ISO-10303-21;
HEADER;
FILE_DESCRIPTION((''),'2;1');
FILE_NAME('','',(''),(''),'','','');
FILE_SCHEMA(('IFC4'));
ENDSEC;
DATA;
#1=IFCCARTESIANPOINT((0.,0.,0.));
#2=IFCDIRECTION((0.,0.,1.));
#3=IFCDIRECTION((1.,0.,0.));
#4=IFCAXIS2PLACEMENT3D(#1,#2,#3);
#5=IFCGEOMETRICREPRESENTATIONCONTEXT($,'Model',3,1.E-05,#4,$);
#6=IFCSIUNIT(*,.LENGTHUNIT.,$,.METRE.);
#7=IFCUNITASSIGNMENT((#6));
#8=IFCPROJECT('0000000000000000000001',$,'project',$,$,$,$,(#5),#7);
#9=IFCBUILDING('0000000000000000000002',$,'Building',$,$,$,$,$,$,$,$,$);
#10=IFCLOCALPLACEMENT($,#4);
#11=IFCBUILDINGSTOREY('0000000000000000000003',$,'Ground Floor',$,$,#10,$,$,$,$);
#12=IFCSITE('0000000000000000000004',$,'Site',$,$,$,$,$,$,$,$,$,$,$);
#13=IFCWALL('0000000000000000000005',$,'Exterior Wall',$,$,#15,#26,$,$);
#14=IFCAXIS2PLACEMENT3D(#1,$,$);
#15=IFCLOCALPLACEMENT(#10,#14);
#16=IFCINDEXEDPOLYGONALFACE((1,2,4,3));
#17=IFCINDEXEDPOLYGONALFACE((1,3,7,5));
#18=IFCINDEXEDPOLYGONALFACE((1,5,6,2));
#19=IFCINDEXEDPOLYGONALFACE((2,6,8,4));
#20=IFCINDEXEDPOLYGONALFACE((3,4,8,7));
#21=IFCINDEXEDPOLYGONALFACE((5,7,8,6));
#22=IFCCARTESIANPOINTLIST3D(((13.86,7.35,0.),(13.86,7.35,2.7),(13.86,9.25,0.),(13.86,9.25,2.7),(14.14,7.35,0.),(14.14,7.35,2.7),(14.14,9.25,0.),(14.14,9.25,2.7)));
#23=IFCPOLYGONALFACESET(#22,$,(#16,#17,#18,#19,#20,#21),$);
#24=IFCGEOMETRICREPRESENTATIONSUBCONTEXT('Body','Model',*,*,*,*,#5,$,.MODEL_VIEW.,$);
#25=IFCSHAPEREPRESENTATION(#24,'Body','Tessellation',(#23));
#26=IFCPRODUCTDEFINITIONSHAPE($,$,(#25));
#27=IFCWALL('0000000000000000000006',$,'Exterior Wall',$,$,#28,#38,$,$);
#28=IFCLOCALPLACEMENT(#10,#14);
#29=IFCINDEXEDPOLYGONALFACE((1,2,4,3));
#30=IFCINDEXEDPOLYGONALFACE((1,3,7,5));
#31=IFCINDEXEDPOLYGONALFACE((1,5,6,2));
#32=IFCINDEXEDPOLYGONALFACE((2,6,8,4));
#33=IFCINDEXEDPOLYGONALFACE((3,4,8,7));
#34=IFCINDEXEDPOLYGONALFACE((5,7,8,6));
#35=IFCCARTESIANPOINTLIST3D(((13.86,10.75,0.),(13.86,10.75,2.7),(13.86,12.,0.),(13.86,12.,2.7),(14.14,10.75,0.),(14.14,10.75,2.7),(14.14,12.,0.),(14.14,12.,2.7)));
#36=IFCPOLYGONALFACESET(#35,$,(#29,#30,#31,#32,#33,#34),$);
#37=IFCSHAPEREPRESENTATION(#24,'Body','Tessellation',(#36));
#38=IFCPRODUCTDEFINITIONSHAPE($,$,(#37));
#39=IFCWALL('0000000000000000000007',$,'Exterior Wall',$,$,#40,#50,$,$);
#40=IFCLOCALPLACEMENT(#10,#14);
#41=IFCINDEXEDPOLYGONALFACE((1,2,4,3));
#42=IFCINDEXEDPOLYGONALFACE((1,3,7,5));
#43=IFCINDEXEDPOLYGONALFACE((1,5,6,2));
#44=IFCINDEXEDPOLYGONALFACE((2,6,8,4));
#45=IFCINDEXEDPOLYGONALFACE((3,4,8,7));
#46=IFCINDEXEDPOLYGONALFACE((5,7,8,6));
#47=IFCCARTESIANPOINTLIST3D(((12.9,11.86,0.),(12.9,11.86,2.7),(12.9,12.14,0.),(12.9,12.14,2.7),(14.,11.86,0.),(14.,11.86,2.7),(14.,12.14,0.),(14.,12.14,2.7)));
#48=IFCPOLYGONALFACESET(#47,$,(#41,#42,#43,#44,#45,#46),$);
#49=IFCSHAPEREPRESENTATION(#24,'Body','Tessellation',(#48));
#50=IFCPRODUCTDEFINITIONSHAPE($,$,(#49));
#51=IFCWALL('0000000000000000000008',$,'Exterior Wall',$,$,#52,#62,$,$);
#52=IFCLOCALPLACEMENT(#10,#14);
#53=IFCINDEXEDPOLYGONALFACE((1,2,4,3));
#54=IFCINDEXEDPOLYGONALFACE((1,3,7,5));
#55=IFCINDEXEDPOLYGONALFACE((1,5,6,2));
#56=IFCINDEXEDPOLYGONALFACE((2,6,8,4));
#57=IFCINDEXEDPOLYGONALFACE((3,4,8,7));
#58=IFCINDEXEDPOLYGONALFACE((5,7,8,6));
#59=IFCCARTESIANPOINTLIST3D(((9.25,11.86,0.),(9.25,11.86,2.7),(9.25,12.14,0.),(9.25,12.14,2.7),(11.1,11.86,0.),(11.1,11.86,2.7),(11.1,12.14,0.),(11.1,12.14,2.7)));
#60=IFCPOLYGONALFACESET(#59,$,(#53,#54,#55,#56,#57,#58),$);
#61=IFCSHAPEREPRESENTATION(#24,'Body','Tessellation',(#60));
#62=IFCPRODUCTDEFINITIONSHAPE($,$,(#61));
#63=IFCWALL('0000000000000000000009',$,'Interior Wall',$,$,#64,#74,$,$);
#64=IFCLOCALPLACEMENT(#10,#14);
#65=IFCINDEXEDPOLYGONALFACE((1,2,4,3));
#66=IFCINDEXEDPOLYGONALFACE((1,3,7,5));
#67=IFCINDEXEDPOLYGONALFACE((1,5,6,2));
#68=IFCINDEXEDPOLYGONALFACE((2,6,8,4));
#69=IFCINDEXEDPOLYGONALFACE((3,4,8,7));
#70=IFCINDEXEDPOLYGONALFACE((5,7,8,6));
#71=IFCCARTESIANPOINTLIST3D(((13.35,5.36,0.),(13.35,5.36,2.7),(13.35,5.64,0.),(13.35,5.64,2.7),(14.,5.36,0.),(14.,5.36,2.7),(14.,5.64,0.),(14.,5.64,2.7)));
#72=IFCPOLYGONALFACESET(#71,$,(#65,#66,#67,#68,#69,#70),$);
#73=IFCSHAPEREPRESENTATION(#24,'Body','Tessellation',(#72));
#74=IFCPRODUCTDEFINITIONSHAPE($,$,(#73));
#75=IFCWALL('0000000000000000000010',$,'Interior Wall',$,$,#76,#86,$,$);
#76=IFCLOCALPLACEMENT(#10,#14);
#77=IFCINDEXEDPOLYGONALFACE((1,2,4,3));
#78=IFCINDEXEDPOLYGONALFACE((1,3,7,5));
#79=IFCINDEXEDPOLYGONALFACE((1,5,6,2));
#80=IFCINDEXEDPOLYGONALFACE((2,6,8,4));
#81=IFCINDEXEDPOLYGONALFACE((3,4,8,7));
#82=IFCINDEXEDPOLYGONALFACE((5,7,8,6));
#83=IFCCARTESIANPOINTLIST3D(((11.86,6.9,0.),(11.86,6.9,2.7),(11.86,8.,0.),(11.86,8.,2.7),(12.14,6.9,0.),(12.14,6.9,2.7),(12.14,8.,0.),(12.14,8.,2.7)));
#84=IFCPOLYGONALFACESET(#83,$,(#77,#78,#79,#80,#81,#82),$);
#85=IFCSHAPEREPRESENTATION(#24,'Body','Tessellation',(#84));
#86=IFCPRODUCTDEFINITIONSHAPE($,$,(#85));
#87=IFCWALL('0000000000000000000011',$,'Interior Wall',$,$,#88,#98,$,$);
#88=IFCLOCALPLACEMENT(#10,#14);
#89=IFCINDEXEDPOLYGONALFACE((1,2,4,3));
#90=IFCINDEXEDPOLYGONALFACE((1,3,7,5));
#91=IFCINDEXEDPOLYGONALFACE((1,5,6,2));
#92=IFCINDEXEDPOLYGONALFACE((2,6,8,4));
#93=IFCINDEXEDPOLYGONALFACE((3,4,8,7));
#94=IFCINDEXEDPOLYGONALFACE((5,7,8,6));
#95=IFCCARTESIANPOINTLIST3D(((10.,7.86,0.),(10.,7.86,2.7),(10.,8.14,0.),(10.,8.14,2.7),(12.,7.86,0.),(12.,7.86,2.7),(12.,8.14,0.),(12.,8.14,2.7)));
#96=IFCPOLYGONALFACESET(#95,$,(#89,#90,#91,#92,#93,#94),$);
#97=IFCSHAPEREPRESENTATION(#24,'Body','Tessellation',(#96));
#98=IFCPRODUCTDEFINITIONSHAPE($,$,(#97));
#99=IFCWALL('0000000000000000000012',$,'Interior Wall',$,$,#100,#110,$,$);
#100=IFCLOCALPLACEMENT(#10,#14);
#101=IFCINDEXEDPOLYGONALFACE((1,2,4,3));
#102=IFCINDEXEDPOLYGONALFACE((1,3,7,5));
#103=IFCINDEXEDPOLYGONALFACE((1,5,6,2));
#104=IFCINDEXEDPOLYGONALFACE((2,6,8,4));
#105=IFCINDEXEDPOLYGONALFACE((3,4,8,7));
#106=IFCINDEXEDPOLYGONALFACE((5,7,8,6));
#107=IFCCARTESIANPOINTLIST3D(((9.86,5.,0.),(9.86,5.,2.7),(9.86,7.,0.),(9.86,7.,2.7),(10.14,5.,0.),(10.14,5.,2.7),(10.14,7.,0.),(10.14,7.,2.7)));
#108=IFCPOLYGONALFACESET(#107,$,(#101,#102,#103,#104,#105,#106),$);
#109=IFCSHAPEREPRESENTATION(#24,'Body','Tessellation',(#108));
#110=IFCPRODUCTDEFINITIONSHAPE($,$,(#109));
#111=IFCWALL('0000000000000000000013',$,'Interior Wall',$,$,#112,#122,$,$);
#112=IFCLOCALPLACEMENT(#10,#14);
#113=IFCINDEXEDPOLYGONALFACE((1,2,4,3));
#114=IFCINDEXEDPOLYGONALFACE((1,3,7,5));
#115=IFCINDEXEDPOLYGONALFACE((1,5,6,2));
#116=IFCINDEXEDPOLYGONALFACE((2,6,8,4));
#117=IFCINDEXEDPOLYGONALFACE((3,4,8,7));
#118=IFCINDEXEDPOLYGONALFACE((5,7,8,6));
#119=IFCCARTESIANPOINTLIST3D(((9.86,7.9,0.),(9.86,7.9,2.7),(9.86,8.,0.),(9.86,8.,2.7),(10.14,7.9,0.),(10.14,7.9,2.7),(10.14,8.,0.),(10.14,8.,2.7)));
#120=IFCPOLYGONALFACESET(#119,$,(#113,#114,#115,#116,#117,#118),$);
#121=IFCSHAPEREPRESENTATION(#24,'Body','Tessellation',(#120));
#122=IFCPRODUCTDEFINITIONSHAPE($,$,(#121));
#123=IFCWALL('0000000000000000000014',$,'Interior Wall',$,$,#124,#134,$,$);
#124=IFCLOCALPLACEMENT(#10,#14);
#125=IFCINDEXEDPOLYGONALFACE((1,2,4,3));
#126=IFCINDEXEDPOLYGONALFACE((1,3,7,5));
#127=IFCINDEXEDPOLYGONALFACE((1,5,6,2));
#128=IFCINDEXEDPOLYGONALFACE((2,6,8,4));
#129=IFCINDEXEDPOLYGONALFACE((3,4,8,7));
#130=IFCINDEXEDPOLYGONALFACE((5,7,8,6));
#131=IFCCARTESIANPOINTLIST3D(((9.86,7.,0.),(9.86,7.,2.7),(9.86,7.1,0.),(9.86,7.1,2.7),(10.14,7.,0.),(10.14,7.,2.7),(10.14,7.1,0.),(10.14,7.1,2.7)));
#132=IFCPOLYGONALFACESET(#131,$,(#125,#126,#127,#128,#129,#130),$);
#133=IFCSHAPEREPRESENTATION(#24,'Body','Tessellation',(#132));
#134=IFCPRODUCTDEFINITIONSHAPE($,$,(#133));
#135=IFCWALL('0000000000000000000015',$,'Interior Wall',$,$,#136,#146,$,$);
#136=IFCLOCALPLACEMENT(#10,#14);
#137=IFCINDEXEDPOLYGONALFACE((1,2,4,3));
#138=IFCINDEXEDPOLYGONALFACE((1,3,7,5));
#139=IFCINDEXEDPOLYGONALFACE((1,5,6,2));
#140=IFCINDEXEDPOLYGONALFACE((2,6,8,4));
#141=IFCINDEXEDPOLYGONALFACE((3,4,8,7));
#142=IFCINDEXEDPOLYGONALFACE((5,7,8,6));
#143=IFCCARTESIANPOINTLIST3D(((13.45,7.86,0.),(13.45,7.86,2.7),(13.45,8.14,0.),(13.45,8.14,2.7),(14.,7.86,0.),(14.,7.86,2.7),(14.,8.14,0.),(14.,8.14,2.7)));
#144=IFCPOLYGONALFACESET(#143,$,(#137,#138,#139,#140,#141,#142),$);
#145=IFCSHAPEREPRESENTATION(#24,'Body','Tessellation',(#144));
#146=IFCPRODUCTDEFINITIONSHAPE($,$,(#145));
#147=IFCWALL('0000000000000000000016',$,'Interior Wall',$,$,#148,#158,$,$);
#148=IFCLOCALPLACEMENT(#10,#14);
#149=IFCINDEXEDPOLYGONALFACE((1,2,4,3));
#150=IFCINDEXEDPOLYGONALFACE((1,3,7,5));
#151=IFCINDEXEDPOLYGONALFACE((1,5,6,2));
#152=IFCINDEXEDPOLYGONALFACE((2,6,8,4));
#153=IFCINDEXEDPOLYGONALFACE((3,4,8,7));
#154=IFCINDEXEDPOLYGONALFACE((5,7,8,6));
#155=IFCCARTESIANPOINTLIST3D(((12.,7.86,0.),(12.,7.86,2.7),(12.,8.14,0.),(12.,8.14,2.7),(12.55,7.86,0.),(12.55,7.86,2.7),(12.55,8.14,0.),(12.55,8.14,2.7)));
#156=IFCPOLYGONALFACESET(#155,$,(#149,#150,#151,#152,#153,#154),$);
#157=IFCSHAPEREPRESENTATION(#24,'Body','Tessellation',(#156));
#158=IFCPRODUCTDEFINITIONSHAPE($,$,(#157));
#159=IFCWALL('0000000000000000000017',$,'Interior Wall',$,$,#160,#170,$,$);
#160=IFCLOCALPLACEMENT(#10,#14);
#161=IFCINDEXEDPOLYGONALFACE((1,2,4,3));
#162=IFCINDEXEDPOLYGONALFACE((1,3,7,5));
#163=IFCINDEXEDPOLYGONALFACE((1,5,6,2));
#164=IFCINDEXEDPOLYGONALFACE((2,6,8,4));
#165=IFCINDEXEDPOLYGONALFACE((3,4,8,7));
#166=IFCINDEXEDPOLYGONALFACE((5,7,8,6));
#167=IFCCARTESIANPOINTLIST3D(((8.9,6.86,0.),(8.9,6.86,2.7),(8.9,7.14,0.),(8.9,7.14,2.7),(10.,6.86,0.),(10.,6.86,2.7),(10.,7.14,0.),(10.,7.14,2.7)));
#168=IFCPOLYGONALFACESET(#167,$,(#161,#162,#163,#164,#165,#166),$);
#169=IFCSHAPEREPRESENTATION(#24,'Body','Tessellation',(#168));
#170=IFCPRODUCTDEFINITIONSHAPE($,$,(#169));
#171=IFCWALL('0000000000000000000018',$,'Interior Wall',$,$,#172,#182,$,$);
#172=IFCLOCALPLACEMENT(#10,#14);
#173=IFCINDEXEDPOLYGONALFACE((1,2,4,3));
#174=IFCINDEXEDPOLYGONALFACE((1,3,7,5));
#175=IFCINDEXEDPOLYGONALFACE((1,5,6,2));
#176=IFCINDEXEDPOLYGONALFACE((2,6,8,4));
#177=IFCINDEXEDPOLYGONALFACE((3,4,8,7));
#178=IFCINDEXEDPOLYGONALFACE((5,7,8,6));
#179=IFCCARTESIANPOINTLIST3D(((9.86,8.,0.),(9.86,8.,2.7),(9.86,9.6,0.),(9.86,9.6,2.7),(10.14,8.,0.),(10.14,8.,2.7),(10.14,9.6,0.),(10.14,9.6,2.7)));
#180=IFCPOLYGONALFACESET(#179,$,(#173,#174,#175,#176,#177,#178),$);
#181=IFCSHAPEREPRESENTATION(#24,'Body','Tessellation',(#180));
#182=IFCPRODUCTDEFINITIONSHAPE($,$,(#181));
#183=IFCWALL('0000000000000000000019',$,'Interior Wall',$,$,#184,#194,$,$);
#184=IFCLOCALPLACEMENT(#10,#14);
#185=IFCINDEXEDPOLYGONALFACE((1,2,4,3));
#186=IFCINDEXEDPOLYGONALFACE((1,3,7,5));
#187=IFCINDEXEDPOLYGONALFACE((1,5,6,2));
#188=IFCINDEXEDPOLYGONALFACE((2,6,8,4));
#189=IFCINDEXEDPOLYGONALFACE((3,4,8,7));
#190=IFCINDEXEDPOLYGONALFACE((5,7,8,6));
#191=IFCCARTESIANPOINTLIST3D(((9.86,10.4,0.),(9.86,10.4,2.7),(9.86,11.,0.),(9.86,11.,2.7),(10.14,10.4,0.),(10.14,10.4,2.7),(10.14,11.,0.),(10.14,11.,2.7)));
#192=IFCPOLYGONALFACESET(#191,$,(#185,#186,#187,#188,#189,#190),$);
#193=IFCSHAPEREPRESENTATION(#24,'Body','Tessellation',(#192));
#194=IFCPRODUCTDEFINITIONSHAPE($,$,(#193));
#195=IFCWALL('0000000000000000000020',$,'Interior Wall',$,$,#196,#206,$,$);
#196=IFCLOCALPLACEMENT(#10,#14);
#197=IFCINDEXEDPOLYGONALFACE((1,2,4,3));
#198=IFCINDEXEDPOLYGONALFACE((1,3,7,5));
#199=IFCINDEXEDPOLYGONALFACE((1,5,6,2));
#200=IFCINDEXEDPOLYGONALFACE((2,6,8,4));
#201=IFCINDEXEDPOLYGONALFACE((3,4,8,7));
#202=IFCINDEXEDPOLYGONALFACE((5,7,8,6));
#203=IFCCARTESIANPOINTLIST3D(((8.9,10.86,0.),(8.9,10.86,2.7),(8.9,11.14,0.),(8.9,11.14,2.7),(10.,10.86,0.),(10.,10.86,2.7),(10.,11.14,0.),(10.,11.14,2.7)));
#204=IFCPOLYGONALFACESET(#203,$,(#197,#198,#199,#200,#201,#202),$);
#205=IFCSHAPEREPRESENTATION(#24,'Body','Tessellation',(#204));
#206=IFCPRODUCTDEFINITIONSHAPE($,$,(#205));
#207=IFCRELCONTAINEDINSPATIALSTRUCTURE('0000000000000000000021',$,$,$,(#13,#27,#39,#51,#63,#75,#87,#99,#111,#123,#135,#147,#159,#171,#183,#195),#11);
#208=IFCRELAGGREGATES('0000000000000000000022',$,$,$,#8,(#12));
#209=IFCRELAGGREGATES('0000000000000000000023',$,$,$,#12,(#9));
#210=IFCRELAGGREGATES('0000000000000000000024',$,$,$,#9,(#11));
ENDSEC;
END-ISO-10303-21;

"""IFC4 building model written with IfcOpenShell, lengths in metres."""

from ifc_helpers import new_model, si_unit, frame, origin_with_axes, place, context, subcontext, project, spatial, indexed_curve, outline, extrude, element, save


model = new_model("IFC4")

# Units and contexts
model_context = context("Model", 3, precision=1e-05, world=origin_with_axes())
body_context = subcontext(model_context, "Body", "Model", "MODEL_VIEW")
ifc_project = project(units=[si_unit("LENGTHUNIT", "METRE")], contexts=[model_context])

# Site, building, storey
site = spatial("IfcSite", under=ifc_project, Name="Site")
building = spatial("IfcBuilding", under=site, Name="Building")
storey_placement = place(None, origin_with_axes())
storey = spatial("IfcBuildingStorey", under=building, at=storey_placement, Name="Ground Floor")

# Walls
wall_1_placement = place(storey_placement, frame((14.0, 7.35, 0.0), z_axis=(0.0, 0.0, 1.0), x_axis=(0.0, 1.0, 0.0)))
element("IfcWall", 1, at=wall_1_placement, inside=storey, Name="Exterior Wall", context=body_context, shape_type="SweptSolid", body=[
    extrude(outline(indexed_curve([(0.0, 0.0), (0.0, 0.28), (1.9, 0.28), (1.9, 0.0), (0.0, 0.0)], self_intersect=False)), frame((0.0, -0.14, 0.0), z_axis=(0.0, 0.0, 1.0), x_axis=(1.0, 0.0, 0.0)), (0.0, 0.0, 1.0), 2.7),
])
wall_2_placement = place(storey_placement, frame((14.0, 10.75, 0.0), z_axis=(0.0, 0.0, 1.0), x_axis=(0.0, 1.0, 0.0)))
element("IfcWall", 2, at=wall_2_placement, inside=storey, Name="Exterior Wall", context=body_context, shape_type="SweptSolid", body=[
    extrude(outline(indexed_curve([(0.0, 0.0), (0.0, 0.28), (1.25, 0.28), (1.25, 0.0), (0.0, 0.0)], self_intersect=False)), frame((0.0, -0.14, 0.0), z_axis=(0.0, 0.0, 1.0), x_axis=(1.0, 0.0, 0.0)), (0.0, 0.0, 1.0), 2.7),
])
wall_3_placement = place(storey_placement, frame((14.0, 12.0, 0.0), z_axis=(0.0, 0.0, 1.0), x_axis=(-1.0, 0.0, 0.0)))
element("IfcWall", 3, at=wall_3_placement, inside=storey, Name="Exterior Wall", context=body_context, shape_type="SweptSolid", body=[
    extrude(outline(indexed_curve([(0.0, 0.0), (0.0, 0.28), (1.1, 0.28), (1.1, 0.0), (0.0, 0.0)], self_intersect=False)), frame((0.0, -0.14, 0.0), z_axis=(0.0, 0.0, 1.0), x_axis=(1.0, 0.0, 0.0)), (0.0, 0.0, 1.0), 2.7),
])
wall_4_placement = place(storey_placement, frame((11.1, 12.0, 0.0), z_axis=(0.0, 0.0, 1.0), x_axis=(-1.0, 0.0, 0.0)))
element("IfcWall", 4, at=wall_4_placement, inside=storey, Name="Exterior Wall", context=body_context, shape_type="SweptSolid", body=[
    extrude(outline(indexed_curve([(0.0, 0.0), (0.0, 0.28), (1.85, 0.28), (1.85, 0.0), (0.0, 0.0)], self_intersect=False)), frame((0.0, -0.14, 0.0), z_axis=(0.0, 0.0, 1.0), x_axis=(1.0, 0.0, 0.0)), (0.0, 0.0, 1.0), 2.7),
])
wall_5_placement = place(storey_placement, frame((14.0, 5.5, 0.0), z_axis=(0.0, 0.0, 1.0), x_axis=(-1.0, 0.0, 0.0)))
element("IfcWall", 5, at=wall_5_placement, inside=storey, Name="Interior Wall", context=body_context, shape_type="SweptSolid", body=[
    extrude(outline(indexed_curve([(0.0, 0.0), (0.0, 0.28), (0.65, 0.28), (0.65, 0.0), (0.0, 0.0)], self_intersect=False)), frame((0.0, -0.14, 0.0), z_axis=(0.0, 0.0, 1.0), x_axis=(1.0, 0.0, 0.0)), (0.0, 0.0, 1.0), 2.7),
])
wall_6_placement = place(storey_placement, frame((12.0, 6.9, 0.0), z_axis=(0.0, 0.0, 1.0), x_axis=(0.0, 1.0, 0.0)))
element("IfcWall", 6, at=wall_6_placement, inside=storey, Name="Interior Wall", context=body_context, shape_type="SweptSolid", body=[
    extrude(outline(indexed_curve([(0.0, 0.0), (0.0, 0.28), (1.1, 0.28), (1.1, 0.0), (0.0, 0.0)], self_intersect=False)), frame((0.0, -0.14, 0.0), z_axis=(0.0, 0.0, 1.0), x_axis=(1.0, 0.0, 0.0)), (0.0, 0.0, 1.0), 2.7),
])
for number, where, z_axis, x_axis, name in (
    (7, (12.0, 8.0, 0.0), (0.0, 0.0, 1.0), (-1.0, 0.0, 0.0), "Interior Wall"),
    (8, (10.0, 7.0, 0.0), (0.0, 0.0, 1.0), (0.0, -1.0, 0.0), "Interior Wall"),
):
    element("IfcWall", number, at=place(storey_placement, frame(where, z_axis=z_axis, x_axis=x_axis)), inside=storey, Name=name, context=body_context, shape_type="SweptSolid", body=[
        extrude(outline(indexed_curve([(0.0, 0.0), (0.0, 0.28), (2.0, 0.28), (2.0, 0.0), (0.0, 0.0)], self_intersect=False)), frame((0.0, -0.14, 0.0), z_axis=(0.0, 0.0, 1.0), x_axis=(1.0, 0.0, 0.0)), (0.0, 0.0, 1.0), 2.7),
    ])
for number, where, z_axis, x_axis, name in (
    (9, (10.0, 8.0, 0.0), (0.0, 0.0, 1.0), (0.0, -1.0, 0.0), "Interior Wall"),
    (10, (10.0, 7.1, 0.0), (0.0, 0.0, 1.0), (0.0, -1.0, 0.0), "Interior Wall"),
):
    element("IfcWall", number, at=place(storey_placement, frame(where, z_axis=z_axis, x_axis=x_axis)), inside=storey, Name=name, context=body_context, shape_type="SweptSolid", body=[
        extrude(outline(indexed_curve([(0.0, 0.0), (0.0, 0.28), (0.1, 0.28), (0.1, 0.0), (0.0, 0.0)], self_intersect=False)), frame((0.0, -0.14, 0.0), z_axis=(0.0, 0.0, 1.0), x_axis=(1.0, 0.0, 0.0)), (0.0, 0.0, 1.0), 2.7),
    ])
for number, where, z_axis, x_axis, name in (
    (11, (14.0, 8.0, 0.0), (0.0, 0.0, 1.0), (-1.0, 0.0, 0.0), "Interior Wall"),
    (12, (12.55, 8.0, 0.0), (0.0, 0.0, 1.0), (-1.0, 0.0, 0.0), "Interior Wall"),
):
    element("IfcWall", number, at=place(storey_placement, frame(where, z_axis=z_axis, x_axis=x_axis)), inside=storey, Name=name, context=body_context, shape_type="SweptSolid", body=[
        extrude(outline(indexed_curve([(0.0, 0.0), (0.0, 0.28), (0.55, 0.28), (0.55, 0.0), (0.0, 0.0)], self_intersect=False)), frame((0.0, -0.14, 0.0), z_axis=(0.0, 0.0, 1.0), x_axis=(1.0, 0.0, 0.0)), (0.0, 0.0, 1.0), 2.7),
    ])
wall_7_placement = place(storey_placement, frame((10.0, 7.0, 0.0), z_axis=(0.0, 0.0, 1.0), x_axis=(-1.0, 0.0, 0.0)))
element("IfcWall", 13, at=wall_7_placement, inside=storey, Name="Interior Wall", context=body_context, shape_type="SweptSolid", body=[
    extrude(outline(indexed_curve([(0.0, 0.0), (0.0, 0.28), (1.1, 0.28), (1.1, 0.0), (0.0, 0.0)], self_intersect=False)), frame((0.0, -0.14, 0.0), z_axis=(0.0, 0.0, 1.0), x_axis=(1.0, 0.0, 0.0)), (0.0, 0.0, 1.0), 2.7),
])
wall_8_placement = place(storey_placement, frame((10.0, 8.0, 0.0), z_axis=(0.0, 0.0, 1.0), x_axis=(0.0, 1.0, 0.0)))
element("IfcWall", 14, at=wall_8_placement, inside=storey, Name="Interior Wall", context=body_context, shape_type="SweptSolid", body=[
    extrude(outline(indexed_curve([(0.0, 0.0), (0.0, 0.28), (1.6, 0.28), (1.6, 0.0), (0.0, 0.0)], self_intersect=False)), frame((0.0, -0.14, 0.0), z_axis=(0.0, 0.0, 1.0), x_axis=(1.0, 0.0, 0.0)), (0.0, 0.0, 1.0), 2.7),
])
wall_9_placement = place(storey_placement, frame((10.0, 10.4, 0.0), z_axis=(0.0, 0.0, 1.0), x_axis=(0.0, 1.0, 0.0)))
element("IfcWall", 15, at=wall_9_placement, inside=storey, Name="Interior Wall", context=body_context, shape_type="SweptSolid", body=[
    extrude(outline(indexed_curve([(0.0, 0.0), (0.0, 0.28), (0.6, 0.28), (0.6, 0.0), (0.0, 0.0)], self_intersect=False)), frame((0.0, -0.14, 0.0), z_axis=(0.0, 0.0, 1.0), x_axis=(1.0, 0.0, 0.0)), (0.0, 0.0, 1.0), 2.7),
])
wall_10_placement = place(storey_placement, frame((10.0, 11.0, 0.0), z_axis=(0.0, 0.0, 1.0), x_axis=(-1.0, 0.0, 0.0)))
element("IfcWall", 16, at=wall_10_placement, inside=storey, Name="Interior Wall", context=body_context, shape_type="SweptSolid", body=[
    extrude(outline(indexed_curve([(0.0, 0.0), (0.0, 0.28), (1.1, 0.28), (1.1, 0.0), (0.0, 0.0)], self_intersect=False)), frame((0.0, -0.14, 0.0), z_axis=(0.0, 0.0, 1.0), x_axis=(1.0, 0.0, 0.0)), (0.0, 0.0, 1.0), 2.7),
])

save(model, "model.ifc")
